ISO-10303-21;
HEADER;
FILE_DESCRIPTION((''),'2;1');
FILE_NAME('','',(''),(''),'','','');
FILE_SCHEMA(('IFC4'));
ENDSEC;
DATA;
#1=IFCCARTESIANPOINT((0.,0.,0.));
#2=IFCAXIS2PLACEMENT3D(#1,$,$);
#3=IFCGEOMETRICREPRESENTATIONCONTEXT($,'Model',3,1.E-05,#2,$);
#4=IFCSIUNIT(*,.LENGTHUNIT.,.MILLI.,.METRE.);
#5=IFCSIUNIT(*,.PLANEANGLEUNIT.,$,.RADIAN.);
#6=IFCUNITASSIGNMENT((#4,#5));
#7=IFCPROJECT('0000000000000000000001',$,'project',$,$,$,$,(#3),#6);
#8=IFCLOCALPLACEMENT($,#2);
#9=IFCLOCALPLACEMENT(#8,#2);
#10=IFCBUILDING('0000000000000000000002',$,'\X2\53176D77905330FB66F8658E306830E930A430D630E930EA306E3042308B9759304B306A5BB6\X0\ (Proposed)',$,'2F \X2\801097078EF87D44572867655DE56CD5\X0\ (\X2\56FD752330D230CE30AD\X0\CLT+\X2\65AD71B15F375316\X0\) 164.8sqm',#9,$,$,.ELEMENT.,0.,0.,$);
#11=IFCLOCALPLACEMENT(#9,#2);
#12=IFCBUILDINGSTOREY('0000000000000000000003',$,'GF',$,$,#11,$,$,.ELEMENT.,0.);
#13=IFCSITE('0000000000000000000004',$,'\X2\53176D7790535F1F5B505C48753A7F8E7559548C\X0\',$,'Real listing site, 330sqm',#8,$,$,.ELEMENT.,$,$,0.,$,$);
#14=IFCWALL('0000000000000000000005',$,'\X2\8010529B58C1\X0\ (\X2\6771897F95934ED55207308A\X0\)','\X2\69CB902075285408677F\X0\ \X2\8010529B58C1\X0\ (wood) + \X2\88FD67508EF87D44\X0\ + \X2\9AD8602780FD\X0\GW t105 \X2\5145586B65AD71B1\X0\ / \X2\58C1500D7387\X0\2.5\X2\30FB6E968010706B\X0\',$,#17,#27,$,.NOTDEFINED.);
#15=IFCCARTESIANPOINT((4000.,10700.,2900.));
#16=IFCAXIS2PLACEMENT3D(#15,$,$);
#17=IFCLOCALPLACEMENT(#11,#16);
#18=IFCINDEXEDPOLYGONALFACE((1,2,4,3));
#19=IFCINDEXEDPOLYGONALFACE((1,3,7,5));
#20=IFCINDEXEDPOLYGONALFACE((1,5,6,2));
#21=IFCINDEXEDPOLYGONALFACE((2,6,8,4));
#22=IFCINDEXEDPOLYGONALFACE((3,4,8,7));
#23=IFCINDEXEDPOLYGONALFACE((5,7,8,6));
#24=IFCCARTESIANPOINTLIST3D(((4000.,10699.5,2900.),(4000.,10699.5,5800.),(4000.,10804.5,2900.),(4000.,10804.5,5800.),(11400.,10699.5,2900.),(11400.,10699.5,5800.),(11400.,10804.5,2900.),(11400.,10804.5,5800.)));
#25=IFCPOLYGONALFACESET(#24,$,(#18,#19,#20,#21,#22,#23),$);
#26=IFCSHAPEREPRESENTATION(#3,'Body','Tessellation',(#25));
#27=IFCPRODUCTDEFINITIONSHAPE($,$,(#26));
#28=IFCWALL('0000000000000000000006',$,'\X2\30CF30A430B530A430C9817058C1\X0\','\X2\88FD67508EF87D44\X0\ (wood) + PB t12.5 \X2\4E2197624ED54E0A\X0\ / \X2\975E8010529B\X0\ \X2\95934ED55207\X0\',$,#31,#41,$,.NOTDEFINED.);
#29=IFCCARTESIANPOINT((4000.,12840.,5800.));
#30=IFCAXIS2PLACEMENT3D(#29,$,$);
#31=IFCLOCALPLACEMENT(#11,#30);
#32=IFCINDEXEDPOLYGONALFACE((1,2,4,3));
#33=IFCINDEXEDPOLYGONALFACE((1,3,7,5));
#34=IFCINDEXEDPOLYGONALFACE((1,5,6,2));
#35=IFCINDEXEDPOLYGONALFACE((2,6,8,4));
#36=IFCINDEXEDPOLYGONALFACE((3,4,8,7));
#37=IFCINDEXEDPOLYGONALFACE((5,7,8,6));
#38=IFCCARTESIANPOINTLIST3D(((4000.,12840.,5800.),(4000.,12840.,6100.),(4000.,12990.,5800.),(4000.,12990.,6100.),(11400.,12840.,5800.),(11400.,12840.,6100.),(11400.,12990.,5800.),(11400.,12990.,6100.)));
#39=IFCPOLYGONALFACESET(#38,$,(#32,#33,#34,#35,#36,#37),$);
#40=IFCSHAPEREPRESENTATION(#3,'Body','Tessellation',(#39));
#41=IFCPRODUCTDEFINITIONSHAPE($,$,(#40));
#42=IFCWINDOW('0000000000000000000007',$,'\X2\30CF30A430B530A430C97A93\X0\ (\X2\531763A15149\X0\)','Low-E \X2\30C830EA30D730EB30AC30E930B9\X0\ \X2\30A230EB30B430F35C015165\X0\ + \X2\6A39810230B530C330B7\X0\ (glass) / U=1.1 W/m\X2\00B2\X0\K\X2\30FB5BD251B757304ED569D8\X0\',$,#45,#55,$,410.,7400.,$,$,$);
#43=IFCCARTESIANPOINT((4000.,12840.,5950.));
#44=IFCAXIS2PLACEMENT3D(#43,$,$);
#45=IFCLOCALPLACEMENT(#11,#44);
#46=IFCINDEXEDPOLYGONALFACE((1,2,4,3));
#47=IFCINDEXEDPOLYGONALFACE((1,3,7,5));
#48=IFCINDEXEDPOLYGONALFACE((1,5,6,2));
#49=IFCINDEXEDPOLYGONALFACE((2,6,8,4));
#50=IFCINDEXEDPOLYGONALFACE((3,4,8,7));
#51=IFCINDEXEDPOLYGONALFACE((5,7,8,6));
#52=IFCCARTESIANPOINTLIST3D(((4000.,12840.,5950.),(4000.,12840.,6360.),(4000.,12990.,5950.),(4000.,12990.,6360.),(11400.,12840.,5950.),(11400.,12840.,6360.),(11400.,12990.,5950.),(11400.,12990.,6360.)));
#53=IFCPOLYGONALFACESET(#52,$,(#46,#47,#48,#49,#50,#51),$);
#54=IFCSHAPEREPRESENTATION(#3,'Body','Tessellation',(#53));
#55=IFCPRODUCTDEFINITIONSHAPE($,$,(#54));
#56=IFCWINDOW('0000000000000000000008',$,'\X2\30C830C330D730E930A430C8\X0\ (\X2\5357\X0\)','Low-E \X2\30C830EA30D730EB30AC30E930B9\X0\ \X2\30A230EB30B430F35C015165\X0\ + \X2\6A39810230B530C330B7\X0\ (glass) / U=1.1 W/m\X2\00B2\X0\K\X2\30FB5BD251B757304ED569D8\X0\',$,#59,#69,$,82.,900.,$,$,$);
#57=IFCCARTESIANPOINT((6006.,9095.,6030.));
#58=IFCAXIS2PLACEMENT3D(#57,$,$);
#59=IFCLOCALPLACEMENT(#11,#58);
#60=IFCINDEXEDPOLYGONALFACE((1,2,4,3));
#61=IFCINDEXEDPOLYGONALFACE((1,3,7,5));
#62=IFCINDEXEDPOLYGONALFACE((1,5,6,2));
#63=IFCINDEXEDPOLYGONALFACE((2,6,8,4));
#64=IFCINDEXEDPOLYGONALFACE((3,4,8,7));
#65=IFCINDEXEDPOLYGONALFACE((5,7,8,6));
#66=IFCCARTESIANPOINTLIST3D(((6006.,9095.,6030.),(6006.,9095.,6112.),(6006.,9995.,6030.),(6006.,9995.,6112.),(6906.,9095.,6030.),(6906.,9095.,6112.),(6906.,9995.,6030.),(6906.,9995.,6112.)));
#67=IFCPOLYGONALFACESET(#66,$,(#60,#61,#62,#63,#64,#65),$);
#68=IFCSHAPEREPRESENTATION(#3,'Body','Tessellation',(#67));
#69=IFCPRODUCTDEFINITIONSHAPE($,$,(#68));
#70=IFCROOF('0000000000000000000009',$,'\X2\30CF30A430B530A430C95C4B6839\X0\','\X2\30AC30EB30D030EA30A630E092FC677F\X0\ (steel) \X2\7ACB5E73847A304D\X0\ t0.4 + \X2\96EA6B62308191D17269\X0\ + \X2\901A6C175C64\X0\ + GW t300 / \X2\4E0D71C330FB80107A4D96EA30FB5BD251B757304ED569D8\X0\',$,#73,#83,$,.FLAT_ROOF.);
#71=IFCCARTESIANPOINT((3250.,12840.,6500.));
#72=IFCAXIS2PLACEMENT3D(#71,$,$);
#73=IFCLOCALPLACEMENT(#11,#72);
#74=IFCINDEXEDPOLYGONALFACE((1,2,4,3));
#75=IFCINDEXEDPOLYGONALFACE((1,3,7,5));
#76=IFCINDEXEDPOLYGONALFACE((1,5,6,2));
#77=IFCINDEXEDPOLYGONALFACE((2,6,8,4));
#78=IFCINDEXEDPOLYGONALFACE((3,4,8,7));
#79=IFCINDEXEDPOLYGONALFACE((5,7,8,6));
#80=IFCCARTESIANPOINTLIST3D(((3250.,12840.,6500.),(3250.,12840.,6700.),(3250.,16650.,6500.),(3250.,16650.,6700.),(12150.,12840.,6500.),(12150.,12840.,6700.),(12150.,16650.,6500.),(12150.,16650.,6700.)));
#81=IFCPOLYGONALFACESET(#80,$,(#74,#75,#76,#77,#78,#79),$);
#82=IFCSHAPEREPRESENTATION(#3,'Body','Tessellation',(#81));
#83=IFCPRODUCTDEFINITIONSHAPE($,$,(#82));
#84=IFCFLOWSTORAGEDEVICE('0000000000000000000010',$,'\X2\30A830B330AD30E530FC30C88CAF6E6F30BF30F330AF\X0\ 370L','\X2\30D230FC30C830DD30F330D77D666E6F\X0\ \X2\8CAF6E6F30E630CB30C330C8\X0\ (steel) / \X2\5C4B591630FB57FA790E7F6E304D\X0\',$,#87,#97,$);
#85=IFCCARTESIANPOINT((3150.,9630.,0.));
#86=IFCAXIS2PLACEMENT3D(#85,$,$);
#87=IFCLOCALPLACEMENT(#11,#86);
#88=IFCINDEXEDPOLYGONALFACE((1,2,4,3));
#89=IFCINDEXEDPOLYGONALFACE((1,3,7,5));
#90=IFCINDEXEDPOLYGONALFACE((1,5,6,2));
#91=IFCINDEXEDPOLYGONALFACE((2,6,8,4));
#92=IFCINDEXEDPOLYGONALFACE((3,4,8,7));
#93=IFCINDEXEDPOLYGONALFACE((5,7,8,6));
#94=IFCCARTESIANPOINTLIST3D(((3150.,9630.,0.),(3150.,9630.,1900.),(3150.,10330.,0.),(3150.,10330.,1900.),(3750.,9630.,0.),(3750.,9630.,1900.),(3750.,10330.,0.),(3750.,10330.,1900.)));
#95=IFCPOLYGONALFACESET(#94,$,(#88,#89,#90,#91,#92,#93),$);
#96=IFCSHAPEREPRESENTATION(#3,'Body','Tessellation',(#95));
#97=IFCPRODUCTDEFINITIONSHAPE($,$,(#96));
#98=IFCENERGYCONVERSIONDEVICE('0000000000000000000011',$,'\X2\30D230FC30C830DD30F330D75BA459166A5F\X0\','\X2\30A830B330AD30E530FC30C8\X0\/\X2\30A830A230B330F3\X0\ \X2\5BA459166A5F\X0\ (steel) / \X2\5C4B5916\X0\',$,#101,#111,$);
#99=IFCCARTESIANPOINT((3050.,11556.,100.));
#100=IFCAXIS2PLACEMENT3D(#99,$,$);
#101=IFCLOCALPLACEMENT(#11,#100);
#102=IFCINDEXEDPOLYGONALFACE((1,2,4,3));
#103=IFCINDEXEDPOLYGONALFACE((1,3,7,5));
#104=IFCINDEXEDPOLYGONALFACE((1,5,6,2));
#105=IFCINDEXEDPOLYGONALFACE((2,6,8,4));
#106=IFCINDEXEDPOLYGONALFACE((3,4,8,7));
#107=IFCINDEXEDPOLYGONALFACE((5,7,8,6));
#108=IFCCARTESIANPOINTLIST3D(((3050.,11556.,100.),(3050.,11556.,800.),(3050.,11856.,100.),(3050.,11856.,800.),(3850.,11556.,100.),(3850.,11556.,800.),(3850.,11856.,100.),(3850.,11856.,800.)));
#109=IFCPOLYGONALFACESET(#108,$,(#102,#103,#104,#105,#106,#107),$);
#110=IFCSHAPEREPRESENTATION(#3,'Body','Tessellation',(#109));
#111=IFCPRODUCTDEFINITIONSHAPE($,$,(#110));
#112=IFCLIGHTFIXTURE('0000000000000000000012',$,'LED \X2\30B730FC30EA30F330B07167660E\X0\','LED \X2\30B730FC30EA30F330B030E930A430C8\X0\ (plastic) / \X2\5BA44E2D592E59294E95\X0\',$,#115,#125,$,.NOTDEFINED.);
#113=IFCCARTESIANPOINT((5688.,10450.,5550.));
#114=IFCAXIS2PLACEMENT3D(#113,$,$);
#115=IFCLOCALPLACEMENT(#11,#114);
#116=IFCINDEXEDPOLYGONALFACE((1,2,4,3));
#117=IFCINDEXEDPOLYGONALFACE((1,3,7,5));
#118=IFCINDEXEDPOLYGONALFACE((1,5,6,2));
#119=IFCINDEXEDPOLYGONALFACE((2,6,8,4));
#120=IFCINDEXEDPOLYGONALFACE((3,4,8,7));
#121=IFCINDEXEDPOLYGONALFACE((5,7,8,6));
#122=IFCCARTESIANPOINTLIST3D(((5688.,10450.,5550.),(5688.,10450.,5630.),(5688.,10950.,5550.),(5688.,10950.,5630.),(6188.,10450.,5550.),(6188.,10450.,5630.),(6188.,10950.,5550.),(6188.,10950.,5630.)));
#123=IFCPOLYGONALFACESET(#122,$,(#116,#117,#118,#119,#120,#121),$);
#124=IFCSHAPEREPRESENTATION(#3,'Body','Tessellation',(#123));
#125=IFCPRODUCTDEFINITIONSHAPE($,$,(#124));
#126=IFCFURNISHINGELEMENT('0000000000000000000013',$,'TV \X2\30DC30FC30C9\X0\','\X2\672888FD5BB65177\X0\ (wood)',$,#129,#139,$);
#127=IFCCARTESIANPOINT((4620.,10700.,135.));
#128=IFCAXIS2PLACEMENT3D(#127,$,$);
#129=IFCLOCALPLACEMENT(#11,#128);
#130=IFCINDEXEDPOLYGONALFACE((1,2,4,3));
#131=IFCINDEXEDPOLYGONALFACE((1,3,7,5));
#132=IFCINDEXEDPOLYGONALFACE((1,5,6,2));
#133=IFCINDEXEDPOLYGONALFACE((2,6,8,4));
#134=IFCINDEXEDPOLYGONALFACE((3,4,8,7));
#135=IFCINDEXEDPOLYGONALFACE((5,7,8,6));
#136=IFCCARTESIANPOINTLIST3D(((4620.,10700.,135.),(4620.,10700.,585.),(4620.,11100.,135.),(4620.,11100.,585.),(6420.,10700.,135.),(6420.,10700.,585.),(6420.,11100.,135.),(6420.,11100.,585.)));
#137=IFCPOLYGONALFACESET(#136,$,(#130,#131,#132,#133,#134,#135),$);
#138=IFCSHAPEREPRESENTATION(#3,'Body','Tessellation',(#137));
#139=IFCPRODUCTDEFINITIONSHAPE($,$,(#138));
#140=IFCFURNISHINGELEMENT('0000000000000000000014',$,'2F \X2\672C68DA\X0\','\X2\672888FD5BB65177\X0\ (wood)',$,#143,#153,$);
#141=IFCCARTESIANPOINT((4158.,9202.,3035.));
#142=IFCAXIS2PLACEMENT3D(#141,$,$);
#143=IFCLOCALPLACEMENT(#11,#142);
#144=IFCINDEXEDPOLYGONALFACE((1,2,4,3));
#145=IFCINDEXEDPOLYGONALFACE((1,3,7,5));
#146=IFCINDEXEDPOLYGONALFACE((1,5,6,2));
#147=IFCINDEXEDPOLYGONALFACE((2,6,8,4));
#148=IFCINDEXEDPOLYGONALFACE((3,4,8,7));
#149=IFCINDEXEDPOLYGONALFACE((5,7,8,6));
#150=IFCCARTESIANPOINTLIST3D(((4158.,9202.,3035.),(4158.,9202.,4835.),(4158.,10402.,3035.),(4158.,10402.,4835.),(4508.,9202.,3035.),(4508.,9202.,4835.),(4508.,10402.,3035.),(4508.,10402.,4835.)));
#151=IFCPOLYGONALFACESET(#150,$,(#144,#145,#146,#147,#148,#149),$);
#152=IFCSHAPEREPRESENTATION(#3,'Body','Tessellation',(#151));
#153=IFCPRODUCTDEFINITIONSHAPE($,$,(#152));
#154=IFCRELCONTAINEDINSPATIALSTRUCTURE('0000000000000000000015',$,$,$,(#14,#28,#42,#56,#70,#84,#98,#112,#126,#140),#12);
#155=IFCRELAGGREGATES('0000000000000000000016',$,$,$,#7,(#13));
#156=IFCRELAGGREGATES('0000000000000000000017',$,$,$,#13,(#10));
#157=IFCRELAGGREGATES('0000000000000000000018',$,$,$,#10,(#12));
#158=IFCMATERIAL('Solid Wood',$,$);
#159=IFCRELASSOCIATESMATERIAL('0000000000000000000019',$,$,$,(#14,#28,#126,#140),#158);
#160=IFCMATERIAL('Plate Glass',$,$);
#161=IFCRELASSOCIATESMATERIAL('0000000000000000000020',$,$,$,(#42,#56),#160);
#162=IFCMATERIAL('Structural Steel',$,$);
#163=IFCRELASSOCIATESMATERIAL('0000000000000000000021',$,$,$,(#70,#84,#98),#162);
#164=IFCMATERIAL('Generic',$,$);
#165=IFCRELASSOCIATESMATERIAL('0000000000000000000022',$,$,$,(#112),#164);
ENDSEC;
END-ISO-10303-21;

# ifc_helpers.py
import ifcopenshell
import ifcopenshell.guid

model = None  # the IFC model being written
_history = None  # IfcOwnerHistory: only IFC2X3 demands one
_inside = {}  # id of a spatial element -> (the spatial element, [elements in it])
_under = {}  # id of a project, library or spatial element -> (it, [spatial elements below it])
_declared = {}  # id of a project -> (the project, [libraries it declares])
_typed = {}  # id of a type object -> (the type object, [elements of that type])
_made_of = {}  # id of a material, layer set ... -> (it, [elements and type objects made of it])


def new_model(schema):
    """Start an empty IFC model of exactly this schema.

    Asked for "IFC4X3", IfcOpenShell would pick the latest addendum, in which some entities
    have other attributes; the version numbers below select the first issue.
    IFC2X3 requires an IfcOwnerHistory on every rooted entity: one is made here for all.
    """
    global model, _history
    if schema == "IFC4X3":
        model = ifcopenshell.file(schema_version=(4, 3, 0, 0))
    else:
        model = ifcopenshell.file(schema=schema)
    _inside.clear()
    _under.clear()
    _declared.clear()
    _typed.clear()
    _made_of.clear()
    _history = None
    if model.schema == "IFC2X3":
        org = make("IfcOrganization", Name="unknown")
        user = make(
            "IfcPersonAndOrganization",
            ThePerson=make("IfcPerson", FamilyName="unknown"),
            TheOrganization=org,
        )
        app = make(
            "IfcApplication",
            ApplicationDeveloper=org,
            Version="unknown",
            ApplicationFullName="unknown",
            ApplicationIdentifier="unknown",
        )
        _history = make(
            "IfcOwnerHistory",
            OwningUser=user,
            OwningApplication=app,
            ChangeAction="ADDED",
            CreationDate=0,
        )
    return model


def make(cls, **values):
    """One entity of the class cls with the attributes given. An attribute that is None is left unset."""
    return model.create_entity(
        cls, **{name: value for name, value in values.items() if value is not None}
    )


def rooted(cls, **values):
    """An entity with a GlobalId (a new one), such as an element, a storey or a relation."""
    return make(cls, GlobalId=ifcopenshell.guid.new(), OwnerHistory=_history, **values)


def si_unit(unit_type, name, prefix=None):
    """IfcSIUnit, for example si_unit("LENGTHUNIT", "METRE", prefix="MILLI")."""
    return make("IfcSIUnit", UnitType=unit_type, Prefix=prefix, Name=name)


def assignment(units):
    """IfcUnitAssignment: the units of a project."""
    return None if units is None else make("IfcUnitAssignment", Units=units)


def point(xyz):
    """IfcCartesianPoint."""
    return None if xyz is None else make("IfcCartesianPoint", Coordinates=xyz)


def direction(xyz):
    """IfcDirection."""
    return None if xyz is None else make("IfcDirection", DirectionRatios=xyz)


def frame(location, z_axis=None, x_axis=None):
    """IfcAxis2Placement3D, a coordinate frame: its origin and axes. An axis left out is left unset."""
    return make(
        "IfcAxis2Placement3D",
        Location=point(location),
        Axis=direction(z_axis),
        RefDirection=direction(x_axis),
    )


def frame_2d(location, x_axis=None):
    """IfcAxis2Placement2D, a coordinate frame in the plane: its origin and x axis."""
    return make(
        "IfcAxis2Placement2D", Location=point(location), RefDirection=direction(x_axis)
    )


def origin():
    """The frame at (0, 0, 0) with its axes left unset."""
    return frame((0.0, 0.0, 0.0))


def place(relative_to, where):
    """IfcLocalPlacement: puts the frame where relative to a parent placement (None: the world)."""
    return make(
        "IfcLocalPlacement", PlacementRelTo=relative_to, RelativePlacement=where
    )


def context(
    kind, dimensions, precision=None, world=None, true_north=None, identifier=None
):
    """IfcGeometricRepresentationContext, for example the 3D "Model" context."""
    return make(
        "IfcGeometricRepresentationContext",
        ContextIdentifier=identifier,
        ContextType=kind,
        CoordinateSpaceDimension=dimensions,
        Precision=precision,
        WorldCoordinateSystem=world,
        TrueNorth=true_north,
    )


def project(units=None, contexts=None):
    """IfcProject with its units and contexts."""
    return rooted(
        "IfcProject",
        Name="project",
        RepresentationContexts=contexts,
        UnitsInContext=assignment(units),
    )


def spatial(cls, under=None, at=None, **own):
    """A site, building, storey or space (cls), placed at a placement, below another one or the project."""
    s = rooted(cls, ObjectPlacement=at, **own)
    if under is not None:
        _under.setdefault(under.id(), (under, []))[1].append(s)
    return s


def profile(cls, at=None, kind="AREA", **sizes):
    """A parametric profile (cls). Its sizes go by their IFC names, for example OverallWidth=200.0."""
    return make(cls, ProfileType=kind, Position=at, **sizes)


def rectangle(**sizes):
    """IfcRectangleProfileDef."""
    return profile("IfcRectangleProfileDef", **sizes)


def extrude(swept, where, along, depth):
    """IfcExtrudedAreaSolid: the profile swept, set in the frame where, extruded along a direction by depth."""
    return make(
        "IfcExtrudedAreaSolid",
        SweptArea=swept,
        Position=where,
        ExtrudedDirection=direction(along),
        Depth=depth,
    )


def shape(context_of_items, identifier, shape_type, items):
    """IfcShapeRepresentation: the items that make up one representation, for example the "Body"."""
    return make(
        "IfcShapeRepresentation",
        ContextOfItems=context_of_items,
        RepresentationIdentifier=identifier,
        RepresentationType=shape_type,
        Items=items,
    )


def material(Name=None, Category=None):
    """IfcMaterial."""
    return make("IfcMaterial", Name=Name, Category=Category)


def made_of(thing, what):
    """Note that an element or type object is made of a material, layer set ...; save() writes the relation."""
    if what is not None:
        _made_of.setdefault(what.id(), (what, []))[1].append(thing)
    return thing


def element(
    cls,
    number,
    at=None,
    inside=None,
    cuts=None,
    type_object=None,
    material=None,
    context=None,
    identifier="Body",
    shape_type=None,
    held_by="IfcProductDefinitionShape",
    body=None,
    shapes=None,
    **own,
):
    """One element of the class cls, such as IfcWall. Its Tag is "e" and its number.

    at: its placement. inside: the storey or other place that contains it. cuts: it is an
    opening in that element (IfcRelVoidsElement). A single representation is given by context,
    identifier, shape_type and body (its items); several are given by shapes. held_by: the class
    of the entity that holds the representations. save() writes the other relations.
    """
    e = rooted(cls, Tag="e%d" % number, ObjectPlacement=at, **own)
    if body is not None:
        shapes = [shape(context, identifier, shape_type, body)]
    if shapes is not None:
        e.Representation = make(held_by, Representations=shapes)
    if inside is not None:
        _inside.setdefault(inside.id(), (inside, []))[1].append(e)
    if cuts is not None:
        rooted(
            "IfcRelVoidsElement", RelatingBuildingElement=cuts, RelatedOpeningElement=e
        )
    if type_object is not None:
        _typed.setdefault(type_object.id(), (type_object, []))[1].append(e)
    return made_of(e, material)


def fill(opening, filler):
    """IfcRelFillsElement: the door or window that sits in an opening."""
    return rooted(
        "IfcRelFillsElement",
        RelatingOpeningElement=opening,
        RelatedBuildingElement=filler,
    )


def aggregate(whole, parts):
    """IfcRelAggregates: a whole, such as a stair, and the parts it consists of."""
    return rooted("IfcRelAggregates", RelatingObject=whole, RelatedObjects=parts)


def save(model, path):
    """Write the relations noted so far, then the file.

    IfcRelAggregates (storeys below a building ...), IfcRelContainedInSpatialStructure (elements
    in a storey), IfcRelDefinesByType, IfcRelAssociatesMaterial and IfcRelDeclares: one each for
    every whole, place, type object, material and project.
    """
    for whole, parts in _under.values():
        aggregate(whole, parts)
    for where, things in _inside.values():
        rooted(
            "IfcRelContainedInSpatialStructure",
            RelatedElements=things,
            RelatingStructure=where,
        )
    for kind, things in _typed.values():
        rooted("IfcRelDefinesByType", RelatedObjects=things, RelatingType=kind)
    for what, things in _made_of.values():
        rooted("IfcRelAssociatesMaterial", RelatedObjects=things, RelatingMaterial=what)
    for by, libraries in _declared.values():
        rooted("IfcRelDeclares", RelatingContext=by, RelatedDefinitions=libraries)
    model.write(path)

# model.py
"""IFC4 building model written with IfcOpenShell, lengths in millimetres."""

from ifc_helpers import new_model, si_unit, frame, frame_2d, origin, place, context, project, spatial, rectangle, extrude, material, element, fill, save


model = new_model("IFC4")

# Units and contexts
model_context = context("Model", 3, precision=1e-05, world=origin())
ifc_project = project(units=[si_unit("LENGTHUNIT", "METRE", prefix="MILLI"), si_unit("PLANEANGLEUNIT", "RADIAN")], contexts=[model_context])

# Site, building, storey
site_placement = place(None, origin())
site = spatial("IfcSite", under=ifc_project, at=site_placement, Name="北海道弟子屈町美留和", ObjectType="Real listing site, 330sqm", CompositionType="ELEMENT", RefElevation=0.0)
building_placement = place(site_placement, origin())
building = spatial("IfcBuilding", under=site, at=building_placement, Name="北海道・書斎とライブラリのある静かな家 (Proposed)", ObjectType="2F 耐震軸組在来工法 (国産ヒノキCLT+断熱強化) 164.8sqm", CompositionType="ELEMENT", ElevationOfRefHeight=0.0, ElevationOfTerrain=0.0)
storey_placement = place(building_placement, origin())
storey = spatial("IfcBuildingStorey", under=building, at=storey_placement, Name="GF", CompositionType="ELEMENT", Elevation=0.0)

# Shared definitions
ifc_material_1 = material(Name="Solid Wood")

# Wall
wall_1_placement = place(storey_placement, frame((4000.0, 10700.0, 2900.0)))
element("IfcWall", 1, at=wall_1_placement, inside=storey, material=ifc_material_1, Name="耐力壁 (東西間仕切り)", Description="構造用合板 耐力壁 (wood) + 製材軸組 + 高性能GW t105 充填断熱 / 壁倍率2.5・準耐火", PredefinedType="NOTDEFINED", context=model_context, shape_type="SweptSolid", body=[
    extrude(rectangle(XDim=7400.0, YDim=105.0, at=frame_2d((3700.0, 52.0))), frame((4000.0, 10700.0, 2900.0)), (0.0, 0.0, 1.0), 2900.0),
])

# Wall, opening, window
wall_2_placement = place(storey_placement, frame((4000.0, 12840.0, 5800.0)))
wall_2 = element("IfcWall", 2, at=wall_2_placement, inside=storey, material=ifc_material_1, Name="ハイサイド腰壁", Description="製材軸組 (wood) + PB t12.5 両面仕上 / 非耐力 間仕切", PredefinedType="NOTDEFINED", context=model_context, shape_type="SweptSolid", body=[
    extrude(rectangle(XDim=7400.0, YDim=150.0, at=frame_2d((3700.0, 75.0))), frame((4000.0, 12840.0, 5800.0)), (0.0, 0.0, 1.0), 700.0),
])
opening_1_placement = place(storey_placement, frame((4000.0, 12840.0, 5950.0)))
opening_1 = element("IfcOpeningElement", 3, at=opening_1_placement, cuts=wall_2, PredefinedType="NOTDEFINED", context=model_context, shape_type="SweptSolid", body=[
    extrude(rectangle(XDim=7400.0, YDim=150.0, at=frame_2d((3700.0, 75.0))), frame((4000.0, 12840.0, 5950.0)), (0.0, 0.0, 1.0), 410.0),
])
ifc_material_2 = material(Name="Plate Glass")
window_1_placement = place(storey_placement, frame((4000.0, 12840.0, 5950.0)))
window_1 = element("IfcWindow", 4, at=window_1_placement, inside=storey, material=ifc_material_2, Name="ハイサイド窓 (北採光)", Description="Low-E トリプルガラス アルゴン封入 + 樹脂サッシ (glass) / U=1.1 W/m²K・寒冷地仕様", OverallHeight=410.0, OverallWidth=7400.0, context=model_context, shape_type="SweptSolid", body=[
    extrude(rectangle(XDim=7400.0, YDim=150.0, at=frame_2d((3700.0, 75.0))), frame((4000.0, 12840.0, 5950.0)), (0.0, 0.0, 1.0), 410.0),
])
fill(opening_1, window_1)

# Window
window_2_placement = place(storey_placement, frame((6006.0, 9095.0, 6030.0)))
element("IfcWindow", 5, at=window_2_placement, inside=storey, material=ifc_material_2, Name="トップライト (南)", Description="Low-E トリプルガラス アルゴン封入 + 樹脂サッシ (glass) / U=1.1 W/m²K・寒冷地仕様", OverallHeight=82.0, OverallWidth=900.0, context=model_context, shape_type="SweptSolid", body=[
    extrude(rectangle(XDim=900.0, YDim=900.0, at=frame_2d((450.0, 450.0))), frame((6006.0, 9095.0, 6030.0)), (0.0, 0.0, 1.0), 82.0),
])

# Roof
ifc_material_3 = material(Name="Structural Steel")
roof_placement = place(storey_placement, frame((3250.0, 12840.0, 6500.0)))
element("IfcRoof", 6, at=roof_placement, inside=storey, material=ifc_material_3, Name="ハイサイド屋根", Description="ガルバリウム鋼板 (steel) 立平葺き t0.4 + 雪止め金物 + 通気層 + GW t300 / 不燃・耐積雪・寒冷地仕様", PredefinedType="FLAT_ROOF", context=model_context, shape_type="SweptSolid", body=[
    extrude(rectangle(XDim=8900.0, YDim=3810.0, at=frame_2d((4450.0, 1905.0))), frame((3250.0, 12840.0, 6500.0)), (0.0, 0.0, 1.0), 200.0),
])

# Flow storage device
flow_storage_device_placement = place(storey_placement, frame((3150.0, 9630.0, 0.0)))
element("IfcFlowStorageDevice", 7, at=flow_storage_device_placement, inside=storey, material=ifc_material_3, Name="エコキュート貯湯タンク 370L", Description="ヒートポンプ給湯 貯湯ユニット (steel) / 屋外・基礎置き", context=model_context, shape_type="SweptSolid", body=[
    extrude(rectangle(XDim=600.0, YDim=700.0, at=frame_2d((300.0, 350.0))), frame((3150.0, 9630.0, 0.0)), (0.0, 0.0, 1.0), 1900.0),
])

# Energy conversion device
energy_conversion_device_placement = place(storey_placement, frame((3050.0, 11556.0, 100.0)))
element("IfcEnergyConversionDevice", 8, at=energy_conversion_device_placement, inside=storey, material=ifc_material_3, Name="ヒートポンプ室外機", Description="エコキュート/エアコン 室外機 (steel) / 屋外", context=model_context, shape_type="SweptSolid", body=[
    extrude(rectangle(XDim=800.0, YDim=300.0, at=frame_2d((400.0, 150.0))), frame((3050.0, 11556.0, 100.0)), (0.0, 0.0, 1.0), 700.0),
])

# Light fixture
ifc_material_4 = material(Name="Generic")
light_fixture_placement = place(storey_placement, frame((5688.0, 10450.0, 5550.0)))
element("IfcLightFixture", 9, at=light_fixture_placement, inside=storey, material=ifc_material_4, Name="LED シーリング照明", Description="LED シーリングライト (plastic) / 室中央天井", PredefinedType="NOTDEFINED", context=model_context, shape_type="SweptSolid", body=[
    extrude(rectangle(XDim=500.0, YDim=500.0, at=frame_2d((250.0, 250.0))), frame((5688.0, 10450.0, 5550.0)), (0.0, 0.0, 1.0), 80.0),
])

# Furnishing elements
furnishing_1_placement = place(storey_placement, frame((4620.0, 10700.0, 135.0)))
element("IfcFurnishingElement", 10, at=furnishing_1_placement, inside=storey, material=ifc_material_1, Name="TV ボード", Description="木製家具 (wood)", context=model_context, shape_type="SweptSolid", body=[
    extrude(rectangle(XDim=1800.0, YDim=400.0, at=frame_2d((900.0, 200.0))), frame((4620.0, 10700.0, 135.0)), (0.0, 0.0, 1.0), 450.0),
])
furnishing_2_placement = place(storey_placement, frame((4158.0, 9202.0, 3035.0)))
element("IfcFurnishingElement", 11, at=furnishing_2_placement, inside=storey, material=ifc_material_1, Name="2F 本棚", Description="木製家具 (wood)", context=model_context, shape_type="SweptSolid", body=[
    extrude(rectangle(XDim=350.0, YDim=1200.0, at=frame_2d((175.0, 600.0))), frame((4158.0, 9202.0, 3035.0)), (0.0, 0.0, 1.0), 1800.0),
])

save(model, "model.ifc")
